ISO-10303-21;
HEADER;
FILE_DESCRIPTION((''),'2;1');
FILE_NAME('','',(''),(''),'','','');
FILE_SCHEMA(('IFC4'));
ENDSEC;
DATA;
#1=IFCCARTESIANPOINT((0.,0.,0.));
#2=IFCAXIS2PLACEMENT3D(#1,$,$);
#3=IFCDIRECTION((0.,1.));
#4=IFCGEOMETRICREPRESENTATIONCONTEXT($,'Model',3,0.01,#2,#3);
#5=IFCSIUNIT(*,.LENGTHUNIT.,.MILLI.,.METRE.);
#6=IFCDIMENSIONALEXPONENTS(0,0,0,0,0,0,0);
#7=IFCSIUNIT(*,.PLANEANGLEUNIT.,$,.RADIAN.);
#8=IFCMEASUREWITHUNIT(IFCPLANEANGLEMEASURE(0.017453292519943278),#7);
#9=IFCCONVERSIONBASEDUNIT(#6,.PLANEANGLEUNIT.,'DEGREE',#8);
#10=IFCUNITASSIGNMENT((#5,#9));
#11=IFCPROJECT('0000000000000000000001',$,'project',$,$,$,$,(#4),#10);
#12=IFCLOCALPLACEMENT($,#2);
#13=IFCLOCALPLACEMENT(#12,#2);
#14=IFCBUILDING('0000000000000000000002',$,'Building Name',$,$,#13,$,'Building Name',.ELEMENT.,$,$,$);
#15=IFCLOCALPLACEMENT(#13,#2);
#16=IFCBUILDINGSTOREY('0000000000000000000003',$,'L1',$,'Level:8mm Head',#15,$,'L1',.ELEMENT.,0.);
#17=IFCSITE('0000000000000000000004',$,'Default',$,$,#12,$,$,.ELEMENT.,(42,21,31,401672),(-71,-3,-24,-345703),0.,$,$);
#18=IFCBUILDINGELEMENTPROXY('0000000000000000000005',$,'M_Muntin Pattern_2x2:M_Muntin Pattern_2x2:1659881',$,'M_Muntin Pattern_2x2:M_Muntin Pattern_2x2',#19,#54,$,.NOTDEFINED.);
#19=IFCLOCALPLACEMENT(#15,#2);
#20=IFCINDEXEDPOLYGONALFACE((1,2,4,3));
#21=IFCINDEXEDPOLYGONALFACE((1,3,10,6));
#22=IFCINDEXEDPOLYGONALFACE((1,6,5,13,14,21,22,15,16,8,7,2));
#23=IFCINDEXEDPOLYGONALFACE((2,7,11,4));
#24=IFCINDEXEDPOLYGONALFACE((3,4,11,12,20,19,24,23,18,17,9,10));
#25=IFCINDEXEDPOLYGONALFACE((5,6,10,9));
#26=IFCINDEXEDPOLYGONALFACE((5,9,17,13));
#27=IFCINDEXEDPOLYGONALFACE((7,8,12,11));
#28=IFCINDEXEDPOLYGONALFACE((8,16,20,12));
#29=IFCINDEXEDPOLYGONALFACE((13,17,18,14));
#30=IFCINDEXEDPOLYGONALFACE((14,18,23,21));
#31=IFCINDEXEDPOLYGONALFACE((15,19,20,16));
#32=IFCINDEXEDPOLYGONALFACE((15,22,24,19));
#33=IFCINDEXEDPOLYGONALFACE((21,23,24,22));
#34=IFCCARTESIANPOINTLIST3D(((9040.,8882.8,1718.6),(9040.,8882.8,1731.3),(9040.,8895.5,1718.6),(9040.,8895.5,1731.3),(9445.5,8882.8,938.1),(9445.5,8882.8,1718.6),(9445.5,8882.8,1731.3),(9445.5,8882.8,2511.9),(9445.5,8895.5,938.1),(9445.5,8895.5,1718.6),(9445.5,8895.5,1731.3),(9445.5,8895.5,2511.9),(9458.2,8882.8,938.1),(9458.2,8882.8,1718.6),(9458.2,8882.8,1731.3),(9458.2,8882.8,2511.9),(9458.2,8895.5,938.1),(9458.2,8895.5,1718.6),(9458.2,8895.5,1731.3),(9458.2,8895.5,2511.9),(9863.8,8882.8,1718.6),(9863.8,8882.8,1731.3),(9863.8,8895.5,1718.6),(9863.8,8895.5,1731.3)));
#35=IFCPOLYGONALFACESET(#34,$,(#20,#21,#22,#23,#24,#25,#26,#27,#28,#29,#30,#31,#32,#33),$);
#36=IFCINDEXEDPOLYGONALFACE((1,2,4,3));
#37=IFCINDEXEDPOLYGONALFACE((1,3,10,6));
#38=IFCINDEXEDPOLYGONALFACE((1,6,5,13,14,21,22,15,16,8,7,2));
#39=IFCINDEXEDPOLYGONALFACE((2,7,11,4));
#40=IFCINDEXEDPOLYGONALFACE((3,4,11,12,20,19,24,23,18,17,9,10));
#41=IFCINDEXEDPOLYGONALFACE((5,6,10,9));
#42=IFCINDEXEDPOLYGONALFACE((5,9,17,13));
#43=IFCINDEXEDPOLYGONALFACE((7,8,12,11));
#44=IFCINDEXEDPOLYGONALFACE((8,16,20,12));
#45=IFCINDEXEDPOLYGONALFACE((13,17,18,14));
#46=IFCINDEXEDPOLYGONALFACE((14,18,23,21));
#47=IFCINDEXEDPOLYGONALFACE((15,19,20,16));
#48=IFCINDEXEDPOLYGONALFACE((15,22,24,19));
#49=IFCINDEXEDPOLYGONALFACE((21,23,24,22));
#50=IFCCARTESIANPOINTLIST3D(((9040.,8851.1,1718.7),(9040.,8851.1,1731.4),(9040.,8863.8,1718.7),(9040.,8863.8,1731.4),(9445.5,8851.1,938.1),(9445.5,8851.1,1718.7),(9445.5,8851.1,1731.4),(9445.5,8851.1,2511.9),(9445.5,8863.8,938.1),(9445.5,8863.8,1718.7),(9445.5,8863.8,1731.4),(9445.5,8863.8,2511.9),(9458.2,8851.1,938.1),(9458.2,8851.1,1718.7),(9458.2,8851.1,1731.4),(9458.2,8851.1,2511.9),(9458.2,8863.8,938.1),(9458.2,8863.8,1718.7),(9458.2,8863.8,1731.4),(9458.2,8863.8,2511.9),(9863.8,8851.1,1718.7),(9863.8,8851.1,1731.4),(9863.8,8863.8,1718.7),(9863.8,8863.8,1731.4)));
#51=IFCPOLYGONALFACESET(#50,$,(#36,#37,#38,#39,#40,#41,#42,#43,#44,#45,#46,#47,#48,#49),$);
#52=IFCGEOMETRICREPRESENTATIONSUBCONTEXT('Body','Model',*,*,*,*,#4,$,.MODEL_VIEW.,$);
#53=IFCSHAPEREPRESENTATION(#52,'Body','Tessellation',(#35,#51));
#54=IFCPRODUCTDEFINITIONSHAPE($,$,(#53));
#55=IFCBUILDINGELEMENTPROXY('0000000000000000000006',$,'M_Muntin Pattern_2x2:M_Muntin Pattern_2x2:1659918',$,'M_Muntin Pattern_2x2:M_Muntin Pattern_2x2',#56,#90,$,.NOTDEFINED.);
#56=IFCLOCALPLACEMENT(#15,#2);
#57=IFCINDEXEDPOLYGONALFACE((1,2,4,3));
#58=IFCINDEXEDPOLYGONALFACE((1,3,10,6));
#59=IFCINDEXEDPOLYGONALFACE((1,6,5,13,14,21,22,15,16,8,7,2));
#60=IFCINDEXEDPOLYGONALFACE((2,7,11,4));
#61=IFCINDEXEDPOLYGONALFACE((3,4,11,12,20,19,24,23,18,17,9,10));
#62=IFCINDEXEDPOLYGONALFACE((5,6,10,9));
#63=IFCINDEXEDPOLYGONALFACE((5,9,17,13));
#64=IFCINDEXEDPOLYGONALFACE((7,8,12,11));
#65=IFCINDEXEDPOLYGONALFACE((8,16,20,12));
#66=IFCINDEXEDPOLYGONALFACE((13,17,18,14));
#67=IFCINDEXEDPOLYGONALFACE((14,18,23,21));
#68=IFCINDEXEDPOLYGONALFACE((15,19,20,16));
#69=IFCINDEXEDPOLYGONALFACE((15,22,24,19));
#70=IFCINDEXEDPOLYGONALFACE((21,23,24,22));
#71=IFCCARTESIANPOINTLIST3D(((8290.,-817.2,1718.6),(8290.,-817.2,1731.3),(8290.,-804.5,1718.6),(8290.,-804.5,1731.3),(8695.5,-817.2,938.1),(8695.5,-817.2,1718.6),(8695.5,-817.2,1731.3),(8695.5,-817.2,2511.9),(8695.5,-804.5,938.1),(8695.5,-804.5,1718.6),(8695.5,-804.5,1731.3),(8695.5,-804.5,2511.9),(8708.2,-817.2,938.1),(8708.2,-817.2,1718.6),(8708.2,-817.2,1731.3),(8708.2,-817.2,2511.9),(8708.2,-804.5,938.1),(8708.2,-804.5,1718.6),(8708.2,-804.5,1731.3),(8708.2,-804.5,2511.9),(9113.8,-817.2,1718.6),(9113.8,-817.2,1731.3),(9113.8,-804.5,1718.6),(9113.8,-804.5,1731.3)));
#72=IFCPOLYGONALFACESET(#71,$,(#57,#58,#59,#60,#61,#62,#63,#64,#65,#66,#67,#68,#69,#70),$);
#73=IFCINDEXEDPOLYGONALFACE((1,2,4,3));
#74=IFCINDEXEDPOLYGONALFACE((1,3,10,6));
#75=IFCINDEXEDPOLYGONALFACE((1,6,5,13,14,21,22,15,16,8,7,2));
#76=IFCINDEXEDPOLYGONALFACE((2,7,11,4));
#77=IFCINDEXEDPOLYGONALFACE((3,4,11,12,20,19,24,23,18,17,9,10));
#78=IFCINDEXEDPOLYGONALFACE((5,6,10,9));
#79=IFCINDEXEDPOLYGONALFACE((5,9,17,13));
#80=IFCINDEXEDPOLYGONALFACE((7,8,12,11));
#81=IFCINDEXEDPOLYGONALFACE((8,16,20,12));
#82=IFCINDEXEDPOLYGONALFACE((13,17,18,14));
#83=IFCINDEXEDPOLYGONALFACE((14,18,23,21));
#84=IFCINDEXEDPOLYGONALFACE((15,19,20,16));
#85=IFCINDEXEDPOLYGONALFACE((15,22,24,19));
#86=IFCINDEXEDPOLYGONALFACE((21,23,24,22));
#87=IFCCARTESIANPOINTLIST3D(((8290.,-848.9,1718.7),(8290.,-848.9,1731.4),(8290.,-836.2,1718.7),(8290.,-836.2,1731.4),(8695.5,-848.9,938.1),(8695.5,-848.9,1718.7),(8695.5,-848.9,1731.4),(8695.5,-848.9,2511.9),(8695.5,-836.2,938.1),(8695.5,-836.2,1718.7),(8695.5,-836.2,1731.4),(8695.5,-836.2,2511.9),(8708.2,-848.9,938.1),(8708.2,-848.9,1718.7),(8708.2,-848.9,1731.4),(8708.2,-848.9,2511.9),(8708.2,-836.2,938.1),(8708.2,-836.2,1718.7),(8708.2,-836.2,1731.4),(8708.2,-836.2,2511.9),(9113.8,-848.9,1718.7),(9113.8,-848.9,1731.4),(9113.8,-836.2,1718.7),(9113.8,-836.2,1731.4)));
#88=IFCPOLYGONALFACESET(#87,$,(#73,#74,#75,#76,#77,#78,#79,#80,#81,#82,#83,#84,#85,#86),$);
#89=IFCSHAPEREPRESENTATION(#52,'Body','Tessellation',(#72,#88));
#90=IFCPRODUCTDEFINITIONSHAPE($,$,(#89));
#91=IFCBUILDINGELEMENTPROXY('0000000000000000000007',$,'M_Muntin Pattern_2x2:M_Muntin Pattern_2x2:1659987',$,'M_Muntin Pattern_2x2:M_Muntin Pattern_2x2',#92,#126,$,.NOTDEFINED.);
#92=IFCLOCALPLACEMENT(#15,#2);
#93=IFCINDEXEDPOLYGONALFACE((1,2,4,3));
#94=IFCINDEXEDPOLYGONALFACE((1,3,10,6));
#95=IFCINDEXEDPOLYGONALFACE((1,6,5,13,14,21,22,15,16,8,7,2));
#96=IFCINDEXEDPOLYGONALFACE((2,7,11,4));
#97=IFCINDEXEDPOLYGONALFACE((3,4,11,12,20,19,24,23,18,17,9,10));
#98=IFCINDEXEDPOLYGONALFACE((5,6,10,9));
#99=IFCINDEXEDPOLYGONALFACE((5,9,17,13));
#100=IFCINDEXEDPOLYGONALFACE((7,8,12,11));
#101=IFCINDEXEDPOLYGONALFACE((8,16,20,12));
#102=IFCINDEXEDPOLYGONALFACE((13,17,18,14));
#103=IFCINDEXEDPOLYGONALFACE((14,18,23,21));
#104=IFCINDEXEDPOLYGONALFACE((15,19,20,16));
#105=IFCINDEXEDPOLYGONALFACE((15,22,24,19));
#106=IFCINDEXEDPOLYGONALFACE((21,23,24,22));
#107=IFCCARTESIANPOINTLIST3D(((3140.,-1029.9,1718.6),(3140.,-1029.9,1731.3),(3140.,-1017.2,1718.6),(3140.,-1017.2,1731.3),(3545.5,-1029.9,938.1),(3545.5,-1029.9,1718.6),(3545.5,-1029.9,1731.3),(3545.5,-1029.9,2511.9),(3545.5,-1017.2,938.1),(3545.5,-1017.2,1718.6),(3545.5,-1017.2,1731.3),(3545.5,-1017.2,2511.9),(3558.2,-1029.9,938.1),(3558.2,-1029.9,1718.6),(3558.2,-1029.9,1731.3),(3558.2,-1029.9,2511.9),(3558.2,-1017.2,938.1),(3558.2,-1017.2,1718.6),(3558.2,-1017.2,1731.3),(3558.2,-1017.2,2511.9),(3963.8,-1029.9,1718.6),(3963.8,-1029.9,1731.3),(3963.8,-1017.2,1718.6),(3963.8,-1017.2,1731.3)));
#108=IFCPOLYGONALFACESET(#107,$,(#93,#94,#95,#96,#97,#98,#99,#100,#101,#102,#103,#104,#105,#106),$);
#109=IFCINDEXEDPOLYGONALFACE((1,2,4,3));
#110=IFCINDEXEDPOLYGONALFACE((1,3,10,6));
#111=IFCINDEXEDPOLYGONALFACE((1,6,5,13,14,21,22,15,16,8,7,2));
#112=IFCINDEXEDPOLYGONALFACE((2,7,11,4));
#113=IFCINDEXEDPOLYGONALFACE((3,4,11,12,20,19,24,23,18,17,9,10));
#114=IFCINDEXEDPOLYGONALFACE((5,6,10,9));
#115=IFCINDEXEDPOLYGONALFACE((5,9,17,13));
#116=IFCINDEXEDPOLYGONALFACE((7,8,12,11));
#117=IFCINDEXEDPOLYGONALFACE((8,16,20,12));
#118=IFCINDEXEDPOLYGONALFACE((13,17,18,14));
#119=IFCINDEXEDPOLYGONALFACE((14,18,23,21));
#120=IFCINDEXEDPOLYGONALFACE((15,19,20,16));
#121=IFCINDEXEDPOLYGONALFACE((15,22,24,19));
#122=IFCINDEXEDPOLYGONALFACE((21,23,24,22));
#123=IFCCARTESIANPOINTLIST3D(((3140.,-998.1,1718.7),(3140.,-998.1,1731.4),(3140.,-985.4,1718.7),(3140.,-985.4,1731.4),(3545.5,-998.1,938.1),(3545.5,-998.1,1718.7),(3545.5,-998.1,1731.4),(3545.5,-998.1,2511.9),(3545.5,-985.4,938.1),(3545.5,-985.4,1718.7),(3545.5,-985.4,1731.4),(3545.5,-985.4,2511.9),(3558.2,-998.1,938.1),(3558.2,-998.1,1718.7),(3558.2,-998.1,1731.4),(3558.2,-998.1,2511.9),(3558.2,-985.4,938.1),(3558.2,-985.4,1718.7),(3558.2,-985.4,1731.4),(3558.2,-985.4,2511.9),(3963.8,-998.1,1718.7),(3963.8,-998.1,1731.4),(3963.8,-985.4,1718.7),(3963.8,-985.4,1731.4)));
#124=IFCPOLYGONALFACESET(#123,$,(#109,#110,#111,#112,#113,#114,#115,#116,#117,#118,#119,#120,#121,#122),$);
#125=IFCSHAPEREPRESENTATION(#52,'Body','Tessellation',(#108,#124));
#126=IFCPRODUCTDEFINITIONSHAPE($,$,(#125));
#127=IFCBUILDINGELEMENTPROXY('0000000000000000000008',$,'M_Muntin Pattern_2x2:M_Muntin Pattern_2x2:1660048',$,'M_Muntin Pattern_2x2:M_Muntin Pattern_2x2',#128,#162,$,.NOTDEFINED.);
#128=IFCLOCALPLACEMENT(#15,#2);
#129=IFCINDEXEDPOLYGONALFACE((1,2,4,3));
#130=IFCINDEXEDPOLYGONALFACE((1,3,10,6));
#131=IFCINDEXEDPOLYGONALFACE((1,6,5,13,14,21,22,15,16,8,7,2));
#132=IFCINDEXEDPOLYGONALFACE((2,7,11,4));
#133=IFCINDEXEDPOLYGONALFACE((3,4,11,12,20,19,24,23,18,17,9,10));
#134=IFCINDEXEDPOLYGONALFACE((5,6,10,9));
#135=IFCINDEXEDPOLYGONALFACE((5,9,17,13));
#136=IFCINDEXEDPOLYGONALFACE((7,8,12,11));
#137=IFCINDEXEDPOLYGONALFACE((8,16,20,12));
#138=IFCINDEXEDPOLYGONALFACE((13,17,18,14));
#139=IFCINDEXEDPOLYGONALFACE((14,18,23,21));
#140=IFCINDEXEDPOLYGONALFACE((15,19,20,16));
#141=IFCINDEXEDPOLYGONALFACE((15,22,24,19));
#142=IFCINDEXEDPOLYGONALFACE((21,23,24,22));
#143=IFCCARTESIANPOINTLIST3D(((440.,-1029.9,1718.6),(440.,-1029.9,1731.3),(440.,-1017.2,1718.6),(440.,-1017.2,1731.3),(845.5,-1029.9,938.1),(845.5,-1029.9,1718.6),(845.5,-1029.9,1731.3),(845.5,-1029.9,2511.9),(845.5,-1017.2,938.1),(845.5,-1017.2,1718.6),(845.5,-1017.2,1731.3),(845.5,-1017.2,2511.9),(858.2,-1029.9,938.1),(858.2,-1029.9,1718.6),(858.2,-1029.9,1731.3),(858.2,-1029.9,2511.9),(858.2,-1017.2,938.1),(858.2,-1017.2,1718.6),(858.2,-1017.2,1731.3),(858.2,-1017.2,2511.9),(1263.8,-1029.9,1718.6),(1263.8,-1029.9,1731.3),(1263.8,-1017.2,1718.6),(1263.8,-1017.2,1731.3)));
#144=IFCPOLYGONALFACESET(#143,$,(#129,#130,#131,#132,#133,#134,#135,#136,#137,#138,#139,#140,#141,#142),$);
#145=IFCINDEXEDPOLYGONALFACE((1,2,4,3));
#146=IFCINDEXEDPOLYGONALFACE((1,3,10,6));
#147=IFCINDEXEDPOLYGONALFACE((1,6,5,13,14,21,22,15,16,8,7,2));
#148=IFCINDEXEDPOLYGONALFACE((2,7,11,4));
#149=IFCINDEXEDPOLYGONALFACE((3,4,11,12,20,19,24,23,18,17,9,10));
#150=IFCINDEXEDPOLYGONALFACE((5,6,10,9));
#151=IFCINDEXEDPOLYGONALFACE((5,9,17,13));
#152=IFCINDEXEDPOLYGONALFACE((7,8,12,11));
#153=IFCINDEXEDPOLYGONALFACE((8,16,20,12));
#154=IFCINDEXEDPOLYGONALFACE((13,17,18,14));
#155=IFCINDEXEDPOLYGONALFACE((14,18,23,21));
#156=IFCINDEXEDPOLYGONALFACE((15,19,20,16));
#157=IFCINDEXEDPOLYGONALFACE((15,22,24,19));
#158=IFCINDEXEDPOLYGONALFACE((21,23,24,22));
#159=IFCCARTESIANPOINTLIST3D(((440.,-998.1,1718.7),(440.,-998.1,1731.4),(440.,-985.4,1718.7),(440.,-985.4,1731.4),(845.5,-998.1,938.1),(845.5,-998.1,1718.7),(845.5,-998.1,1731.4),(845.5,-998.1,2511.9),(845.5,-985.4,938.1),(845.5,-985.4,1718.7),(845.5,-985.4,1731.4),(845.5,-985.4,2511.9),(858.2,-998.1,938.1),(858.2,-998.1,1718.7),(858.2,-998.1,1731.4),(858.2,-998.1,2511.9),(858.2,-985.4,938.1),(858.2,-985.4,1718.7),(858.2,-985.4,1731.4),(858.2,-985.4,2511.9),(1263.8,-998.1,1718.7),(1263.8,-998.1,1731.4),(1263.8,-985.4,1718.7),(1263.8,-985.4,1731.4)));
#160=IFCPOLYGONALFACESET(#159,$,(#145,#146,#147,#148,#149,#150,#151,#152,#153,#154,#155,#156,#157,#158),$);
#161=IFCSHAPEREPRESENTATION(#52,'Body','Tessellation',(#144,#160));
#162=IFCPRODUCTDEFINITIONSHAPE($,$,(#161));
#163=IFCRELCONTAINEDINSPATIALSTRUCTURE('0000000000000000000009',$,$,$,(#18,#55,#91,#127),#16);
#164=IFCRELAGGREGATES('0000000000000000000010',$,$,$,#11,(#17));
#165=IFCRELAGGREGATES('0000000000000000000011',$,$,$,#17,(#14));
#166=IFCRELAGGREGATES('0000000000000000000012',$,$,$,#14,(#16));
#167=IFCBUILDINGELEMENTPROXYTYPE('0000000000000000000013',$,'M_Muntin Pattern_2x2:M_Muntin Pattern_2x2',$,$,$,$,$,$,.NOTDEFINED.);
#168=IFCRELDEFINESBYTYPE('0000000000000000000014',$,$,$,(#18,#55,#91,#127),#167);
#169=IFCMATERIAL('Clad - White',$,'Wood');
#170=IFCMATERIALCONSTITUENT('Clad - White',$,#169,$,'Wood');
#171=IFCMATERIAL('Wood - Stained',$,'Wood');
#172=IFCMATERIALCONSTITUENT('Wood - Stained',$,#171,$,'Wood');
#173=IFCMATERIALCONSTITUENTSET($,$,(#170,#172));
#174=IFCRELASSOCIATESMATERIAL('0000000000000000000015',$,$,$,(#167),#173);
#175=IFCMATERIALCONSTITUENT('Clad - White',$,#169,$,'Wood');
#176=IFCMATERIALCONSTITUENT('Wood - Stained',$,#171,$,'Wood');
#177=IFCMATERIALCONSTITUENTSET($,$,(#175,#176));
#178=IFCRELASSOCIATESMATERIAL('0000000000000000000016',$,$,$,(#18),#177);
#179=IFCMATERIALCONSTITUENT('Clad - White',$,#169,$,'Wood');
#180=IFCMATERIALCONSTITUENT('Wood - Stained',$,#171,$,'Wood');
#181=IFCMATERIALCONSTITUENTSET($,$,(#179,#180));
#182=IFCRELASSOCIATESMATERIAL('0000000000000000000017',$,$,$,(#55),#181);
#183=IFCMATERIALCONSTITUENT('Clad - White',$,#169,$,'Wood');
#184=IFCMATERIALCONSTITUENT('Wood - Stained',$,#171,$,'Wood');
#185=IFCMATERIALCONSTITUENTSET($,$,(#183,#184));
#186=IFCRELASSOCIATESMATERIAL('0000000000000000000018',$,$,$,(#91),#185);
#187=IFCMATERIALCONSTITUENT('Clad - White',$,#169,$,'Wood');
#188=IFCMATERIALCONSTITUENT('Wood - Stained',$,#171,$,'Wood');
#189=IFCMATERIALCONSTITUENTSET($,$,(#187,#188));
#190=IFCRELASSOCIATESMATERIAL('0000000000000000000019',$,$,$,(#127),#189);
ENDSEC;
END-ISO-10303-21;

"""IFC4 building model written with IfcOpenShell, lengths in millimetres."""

from ifc_helpers import new_model, entity, si_unit, converted_unit, direction, frame, origin, place, context, subcontext, project, spatial, indexed_curve, outline, extrude, source, transform, mapped, material, constituent, constituent_set, type_object, type_shapes, element, save


model = new_model("IFC4")

# Units and contexts
model_context = context("Model", 3, precision=0.01, world=origin(), true_north=direction((0.0, 1.0)))
body_context = subcontext(model_context, "Body", "Model", "MODEL_VIEW")
ifc_project = project(units=[si_unit("LENGTHUNIT", "METRE", prefix="MILLI"), converted_unit("PLANEANGLEUNIT", "DEGREE", entity("IfcPlaneAngleMeasure", 0.017453292519943278), si_unit("PLANEANGLEUNIT", "RADIAN"), dimensions=[0, 0, 0, 0, 0, 0, 0])], contexts=[model_context])

# Site, building, storey
site_placement = place(None, origin())
site = spatial("IfcSite", under=ifc_project, at=site_placement, Name="Default", CompositionType="ELEMENT", RefLatitude=(42, 21, 31, 401672), RefLongitude=(-71, -3, -24, -345703), RefElevation=0.0)
building_placement = place(site_placement, origin())
building = spatial("IfcBuilding", under=site, at=building_placement, Name="Building Name", LongName="Building Name", CompositionType="ELEMENT")
storey_placement = place(building_placement, origin())
storey = spatial("IfcBuildingStorey", under=building, at=storey_placement, Name="L1", ObjectType="Level:8mm Head", LongName="L1", CompositionType="ELEMENT", Elevation=0.0)

# Building element proxies
ifc_material_1 = material(Name="Clad - White", Category="Wood")
ifc_material_2 = material(Name="Wood - Stained", Category="Wood")
ifc_constituent_1 = constituent(ifc_material_1, Name="Clad - White", Category="Wood")
ifc_constituent_2 = constituent(ifc_material_2, Name="Wood - Stained", Category="Wood")
ifc_constituent_set_1 = constituent_set(constituents=[ifc_constituent_1, ifc_constituent_2])
building_element_proxy_type_1 = type_object("IfcBuildingElementProxyType", Name="M_Muntin Pattern_2x2:M_Muntin Pattern_2x2", PredefinedType="NOTDEFINED", material=ifc_constituent_set_1)
shared_shape_1 = source(origin(), body_context, "Body", "SweptSolid", [
    extrude(outline(indexed_curve([(6.4, -6.4), (786.9, -6.4), (786.9, 6.3), (6.4, 6.3), (6.4, 411.9), (-6.3, 411.9), (-6.3, 6.3), (-786.9, 6.3), (-786.9, -6.4), (-6.3, -6.4), (-6.3, -411.9), (6.4, -411.9), (6.4, -6.4)], self_intersect=False)), frame((0.0, -22.2, 786.9), z_axis=(0.0, 1.0, 0.0), x_axis=(0.0, 0.0, 1.0)), (0.0, 0.0, 1.0), 12.7),
    extrude(outline(indexed_curve([(6.4, -6.4), (786.9, -6.4), (786.9, 6.3), (6.4, 6.3), (6.4, 411.9), (-6.3, 411.9), (-6.3, 6.3), (-786.9, 6.3), (-786.9, -6.4), (-6.3, -6.4), (-6.3, -411.9), (6.4, -411.9), (6.4, -6.4)], self_intersect=False)), frame((0.0, 9.5, 786.9), z_axis=(0.0, 1.0, 0.0), x_axis=(0.0, 0.0, 1.0)), (0.0, 0.0, 1.0), 12.7),
])
type_shapes(building_element_proxy_type_1, [shared_shape_1])
ifc_constituent_3 = constituent(ifc_material_1, Name="Clad - White", Category="Wood")
ifc_constituent_4 = constituent(ifc_material_2, Name="Wood - Stained", Category="Wood")
ifc_constituent_set_2 = constituent_set(constituents=[ifc_constituent_3, ifc_constituent_4])
proxy_1_placement = place(storey_placement, frame((9451.9, 8873.3, 938.1), z_axis=(0.0, 0.0, 1.0), x_axis=(-1.0, 0.0, 0.0)))
element("IfcBuildingElementProxy", 1, at=proxy_1_placement, inside=storey, type_object=building_element_proxy_type_1, material=ifc_constituent_set_2, Name="M_Muntin Pattern_2x2:M_Muntin Pattern_2x2:1659881", ObjectType="M_Muntin Pattern_2x2:M_Muntin Pattern_2x2", PredefinedType="NOTDEFINED", context=body_context, shape_type="MappedRepresentation", body=[
    mapped(shared_shape_1, transform((0.0, 0.0, 0.0), scale=1.0)),
])
ifc_constituent_5 = constituent(ifc_material_1, Name="Clad - White", Category="Wood")
ifc_constituent_6 = constituent(ifc_material_2, Name="Wood - Stained", Category="Wood")
ifc_constituent_set_3 = constituent_set(constituents=[ifc_constituent_5, ifc_constituent_6])
proxy_2_placement = place(storey_placement, frame((8701.9, -826.7, 938.1), z_axis=(0.0, 0.0, 1.0), x_axis=(-1.0, 0.0, 0.0)))
element("IfcBuildingElementProxy", 2, at=proxy_2_placement, inside=storey, type_object=building_element_proxy_type_1, material=ifc_constituent_set_3, Name="M_Muntin Pattern_2x2:M_Muntin Pattern_2x2:1659918", ObjectType="M_Muntin Pattern_2x2:M_Muntin Pattern_2x2", PredefinedType="NOTDEFINED", context=body_context, shape_type="MappedRepresentation", body=[
    mapped(shared_shape_1, transform((0.0, 0.0, 0.0), scale=1.0)),
])
ifc_constituent_7 = constituent(ifc_material_1, Name="Clad - White", Category="Wood")
ifc_constituent_8 = constituent(ifc_material_2, Name="Wood - Stained", Category="Wood")
ifc_constituent_set_4 = constituent_set(constituents=[ifc_constituent_7, ifc_constituent_8])
proxy_3_placement = place(storey_placement, frame((3551.9, -1007.7, 938.1)))
element("IfcBuildingElementProxy", 3, at=proxy_3_placement, inside=storey, type_object=building_element_proxy_type_1, material=ifc_constituent_set_4, Name="M_Muntin Pattern_2x2:M_Muntin Pattern_2x2:1659987", ObjectType="M_Muntin Pattern_2x2:M_Muntin Pattern_2x2", PredefinedType="NOTDEFINED", context=body_context, shape_type="MappedRepresentation", body=[
    mapped(shared_shape_1, transform((0.0, 0.0, 0.0), scale=1.0)),
])
ifc_constituent_9 = constituent(ifc_material_1, Name="Clad - White", Category="Wood")
ifc_constituent_10 = constituent(ifc_material_2, Name="Wood - Stained", Category="Wood")
ifc_constituent_set_5 = constituent_set(constituents=[ifc_constituent_9, ifc_constituent_10])
proxy_4_placement = place(storey_placement, frame((851.9, -1007.7, 938.1)))
element("IfcBuildingElementProxy", 4, at=proxy_4_placement, inside=storey, type_object=building_element_proxy_type_1, material=ifc_constituent_set_5, Name="M_Muntin Pattern_2x2:M_Muntin Pattern_2x2:1660048", ObjectType="M_Muntin Pattern_2x2:M_Muntin Pattern_2x2", PredefinedType="NOTDEFINED", context=body_context, shape_type="MappedRepresentation", body=[
    mapped(shared_shape_1, transform((0.0, 0.0, 0.0), scale=1.0)),
])

save(model, "model.ifc")
